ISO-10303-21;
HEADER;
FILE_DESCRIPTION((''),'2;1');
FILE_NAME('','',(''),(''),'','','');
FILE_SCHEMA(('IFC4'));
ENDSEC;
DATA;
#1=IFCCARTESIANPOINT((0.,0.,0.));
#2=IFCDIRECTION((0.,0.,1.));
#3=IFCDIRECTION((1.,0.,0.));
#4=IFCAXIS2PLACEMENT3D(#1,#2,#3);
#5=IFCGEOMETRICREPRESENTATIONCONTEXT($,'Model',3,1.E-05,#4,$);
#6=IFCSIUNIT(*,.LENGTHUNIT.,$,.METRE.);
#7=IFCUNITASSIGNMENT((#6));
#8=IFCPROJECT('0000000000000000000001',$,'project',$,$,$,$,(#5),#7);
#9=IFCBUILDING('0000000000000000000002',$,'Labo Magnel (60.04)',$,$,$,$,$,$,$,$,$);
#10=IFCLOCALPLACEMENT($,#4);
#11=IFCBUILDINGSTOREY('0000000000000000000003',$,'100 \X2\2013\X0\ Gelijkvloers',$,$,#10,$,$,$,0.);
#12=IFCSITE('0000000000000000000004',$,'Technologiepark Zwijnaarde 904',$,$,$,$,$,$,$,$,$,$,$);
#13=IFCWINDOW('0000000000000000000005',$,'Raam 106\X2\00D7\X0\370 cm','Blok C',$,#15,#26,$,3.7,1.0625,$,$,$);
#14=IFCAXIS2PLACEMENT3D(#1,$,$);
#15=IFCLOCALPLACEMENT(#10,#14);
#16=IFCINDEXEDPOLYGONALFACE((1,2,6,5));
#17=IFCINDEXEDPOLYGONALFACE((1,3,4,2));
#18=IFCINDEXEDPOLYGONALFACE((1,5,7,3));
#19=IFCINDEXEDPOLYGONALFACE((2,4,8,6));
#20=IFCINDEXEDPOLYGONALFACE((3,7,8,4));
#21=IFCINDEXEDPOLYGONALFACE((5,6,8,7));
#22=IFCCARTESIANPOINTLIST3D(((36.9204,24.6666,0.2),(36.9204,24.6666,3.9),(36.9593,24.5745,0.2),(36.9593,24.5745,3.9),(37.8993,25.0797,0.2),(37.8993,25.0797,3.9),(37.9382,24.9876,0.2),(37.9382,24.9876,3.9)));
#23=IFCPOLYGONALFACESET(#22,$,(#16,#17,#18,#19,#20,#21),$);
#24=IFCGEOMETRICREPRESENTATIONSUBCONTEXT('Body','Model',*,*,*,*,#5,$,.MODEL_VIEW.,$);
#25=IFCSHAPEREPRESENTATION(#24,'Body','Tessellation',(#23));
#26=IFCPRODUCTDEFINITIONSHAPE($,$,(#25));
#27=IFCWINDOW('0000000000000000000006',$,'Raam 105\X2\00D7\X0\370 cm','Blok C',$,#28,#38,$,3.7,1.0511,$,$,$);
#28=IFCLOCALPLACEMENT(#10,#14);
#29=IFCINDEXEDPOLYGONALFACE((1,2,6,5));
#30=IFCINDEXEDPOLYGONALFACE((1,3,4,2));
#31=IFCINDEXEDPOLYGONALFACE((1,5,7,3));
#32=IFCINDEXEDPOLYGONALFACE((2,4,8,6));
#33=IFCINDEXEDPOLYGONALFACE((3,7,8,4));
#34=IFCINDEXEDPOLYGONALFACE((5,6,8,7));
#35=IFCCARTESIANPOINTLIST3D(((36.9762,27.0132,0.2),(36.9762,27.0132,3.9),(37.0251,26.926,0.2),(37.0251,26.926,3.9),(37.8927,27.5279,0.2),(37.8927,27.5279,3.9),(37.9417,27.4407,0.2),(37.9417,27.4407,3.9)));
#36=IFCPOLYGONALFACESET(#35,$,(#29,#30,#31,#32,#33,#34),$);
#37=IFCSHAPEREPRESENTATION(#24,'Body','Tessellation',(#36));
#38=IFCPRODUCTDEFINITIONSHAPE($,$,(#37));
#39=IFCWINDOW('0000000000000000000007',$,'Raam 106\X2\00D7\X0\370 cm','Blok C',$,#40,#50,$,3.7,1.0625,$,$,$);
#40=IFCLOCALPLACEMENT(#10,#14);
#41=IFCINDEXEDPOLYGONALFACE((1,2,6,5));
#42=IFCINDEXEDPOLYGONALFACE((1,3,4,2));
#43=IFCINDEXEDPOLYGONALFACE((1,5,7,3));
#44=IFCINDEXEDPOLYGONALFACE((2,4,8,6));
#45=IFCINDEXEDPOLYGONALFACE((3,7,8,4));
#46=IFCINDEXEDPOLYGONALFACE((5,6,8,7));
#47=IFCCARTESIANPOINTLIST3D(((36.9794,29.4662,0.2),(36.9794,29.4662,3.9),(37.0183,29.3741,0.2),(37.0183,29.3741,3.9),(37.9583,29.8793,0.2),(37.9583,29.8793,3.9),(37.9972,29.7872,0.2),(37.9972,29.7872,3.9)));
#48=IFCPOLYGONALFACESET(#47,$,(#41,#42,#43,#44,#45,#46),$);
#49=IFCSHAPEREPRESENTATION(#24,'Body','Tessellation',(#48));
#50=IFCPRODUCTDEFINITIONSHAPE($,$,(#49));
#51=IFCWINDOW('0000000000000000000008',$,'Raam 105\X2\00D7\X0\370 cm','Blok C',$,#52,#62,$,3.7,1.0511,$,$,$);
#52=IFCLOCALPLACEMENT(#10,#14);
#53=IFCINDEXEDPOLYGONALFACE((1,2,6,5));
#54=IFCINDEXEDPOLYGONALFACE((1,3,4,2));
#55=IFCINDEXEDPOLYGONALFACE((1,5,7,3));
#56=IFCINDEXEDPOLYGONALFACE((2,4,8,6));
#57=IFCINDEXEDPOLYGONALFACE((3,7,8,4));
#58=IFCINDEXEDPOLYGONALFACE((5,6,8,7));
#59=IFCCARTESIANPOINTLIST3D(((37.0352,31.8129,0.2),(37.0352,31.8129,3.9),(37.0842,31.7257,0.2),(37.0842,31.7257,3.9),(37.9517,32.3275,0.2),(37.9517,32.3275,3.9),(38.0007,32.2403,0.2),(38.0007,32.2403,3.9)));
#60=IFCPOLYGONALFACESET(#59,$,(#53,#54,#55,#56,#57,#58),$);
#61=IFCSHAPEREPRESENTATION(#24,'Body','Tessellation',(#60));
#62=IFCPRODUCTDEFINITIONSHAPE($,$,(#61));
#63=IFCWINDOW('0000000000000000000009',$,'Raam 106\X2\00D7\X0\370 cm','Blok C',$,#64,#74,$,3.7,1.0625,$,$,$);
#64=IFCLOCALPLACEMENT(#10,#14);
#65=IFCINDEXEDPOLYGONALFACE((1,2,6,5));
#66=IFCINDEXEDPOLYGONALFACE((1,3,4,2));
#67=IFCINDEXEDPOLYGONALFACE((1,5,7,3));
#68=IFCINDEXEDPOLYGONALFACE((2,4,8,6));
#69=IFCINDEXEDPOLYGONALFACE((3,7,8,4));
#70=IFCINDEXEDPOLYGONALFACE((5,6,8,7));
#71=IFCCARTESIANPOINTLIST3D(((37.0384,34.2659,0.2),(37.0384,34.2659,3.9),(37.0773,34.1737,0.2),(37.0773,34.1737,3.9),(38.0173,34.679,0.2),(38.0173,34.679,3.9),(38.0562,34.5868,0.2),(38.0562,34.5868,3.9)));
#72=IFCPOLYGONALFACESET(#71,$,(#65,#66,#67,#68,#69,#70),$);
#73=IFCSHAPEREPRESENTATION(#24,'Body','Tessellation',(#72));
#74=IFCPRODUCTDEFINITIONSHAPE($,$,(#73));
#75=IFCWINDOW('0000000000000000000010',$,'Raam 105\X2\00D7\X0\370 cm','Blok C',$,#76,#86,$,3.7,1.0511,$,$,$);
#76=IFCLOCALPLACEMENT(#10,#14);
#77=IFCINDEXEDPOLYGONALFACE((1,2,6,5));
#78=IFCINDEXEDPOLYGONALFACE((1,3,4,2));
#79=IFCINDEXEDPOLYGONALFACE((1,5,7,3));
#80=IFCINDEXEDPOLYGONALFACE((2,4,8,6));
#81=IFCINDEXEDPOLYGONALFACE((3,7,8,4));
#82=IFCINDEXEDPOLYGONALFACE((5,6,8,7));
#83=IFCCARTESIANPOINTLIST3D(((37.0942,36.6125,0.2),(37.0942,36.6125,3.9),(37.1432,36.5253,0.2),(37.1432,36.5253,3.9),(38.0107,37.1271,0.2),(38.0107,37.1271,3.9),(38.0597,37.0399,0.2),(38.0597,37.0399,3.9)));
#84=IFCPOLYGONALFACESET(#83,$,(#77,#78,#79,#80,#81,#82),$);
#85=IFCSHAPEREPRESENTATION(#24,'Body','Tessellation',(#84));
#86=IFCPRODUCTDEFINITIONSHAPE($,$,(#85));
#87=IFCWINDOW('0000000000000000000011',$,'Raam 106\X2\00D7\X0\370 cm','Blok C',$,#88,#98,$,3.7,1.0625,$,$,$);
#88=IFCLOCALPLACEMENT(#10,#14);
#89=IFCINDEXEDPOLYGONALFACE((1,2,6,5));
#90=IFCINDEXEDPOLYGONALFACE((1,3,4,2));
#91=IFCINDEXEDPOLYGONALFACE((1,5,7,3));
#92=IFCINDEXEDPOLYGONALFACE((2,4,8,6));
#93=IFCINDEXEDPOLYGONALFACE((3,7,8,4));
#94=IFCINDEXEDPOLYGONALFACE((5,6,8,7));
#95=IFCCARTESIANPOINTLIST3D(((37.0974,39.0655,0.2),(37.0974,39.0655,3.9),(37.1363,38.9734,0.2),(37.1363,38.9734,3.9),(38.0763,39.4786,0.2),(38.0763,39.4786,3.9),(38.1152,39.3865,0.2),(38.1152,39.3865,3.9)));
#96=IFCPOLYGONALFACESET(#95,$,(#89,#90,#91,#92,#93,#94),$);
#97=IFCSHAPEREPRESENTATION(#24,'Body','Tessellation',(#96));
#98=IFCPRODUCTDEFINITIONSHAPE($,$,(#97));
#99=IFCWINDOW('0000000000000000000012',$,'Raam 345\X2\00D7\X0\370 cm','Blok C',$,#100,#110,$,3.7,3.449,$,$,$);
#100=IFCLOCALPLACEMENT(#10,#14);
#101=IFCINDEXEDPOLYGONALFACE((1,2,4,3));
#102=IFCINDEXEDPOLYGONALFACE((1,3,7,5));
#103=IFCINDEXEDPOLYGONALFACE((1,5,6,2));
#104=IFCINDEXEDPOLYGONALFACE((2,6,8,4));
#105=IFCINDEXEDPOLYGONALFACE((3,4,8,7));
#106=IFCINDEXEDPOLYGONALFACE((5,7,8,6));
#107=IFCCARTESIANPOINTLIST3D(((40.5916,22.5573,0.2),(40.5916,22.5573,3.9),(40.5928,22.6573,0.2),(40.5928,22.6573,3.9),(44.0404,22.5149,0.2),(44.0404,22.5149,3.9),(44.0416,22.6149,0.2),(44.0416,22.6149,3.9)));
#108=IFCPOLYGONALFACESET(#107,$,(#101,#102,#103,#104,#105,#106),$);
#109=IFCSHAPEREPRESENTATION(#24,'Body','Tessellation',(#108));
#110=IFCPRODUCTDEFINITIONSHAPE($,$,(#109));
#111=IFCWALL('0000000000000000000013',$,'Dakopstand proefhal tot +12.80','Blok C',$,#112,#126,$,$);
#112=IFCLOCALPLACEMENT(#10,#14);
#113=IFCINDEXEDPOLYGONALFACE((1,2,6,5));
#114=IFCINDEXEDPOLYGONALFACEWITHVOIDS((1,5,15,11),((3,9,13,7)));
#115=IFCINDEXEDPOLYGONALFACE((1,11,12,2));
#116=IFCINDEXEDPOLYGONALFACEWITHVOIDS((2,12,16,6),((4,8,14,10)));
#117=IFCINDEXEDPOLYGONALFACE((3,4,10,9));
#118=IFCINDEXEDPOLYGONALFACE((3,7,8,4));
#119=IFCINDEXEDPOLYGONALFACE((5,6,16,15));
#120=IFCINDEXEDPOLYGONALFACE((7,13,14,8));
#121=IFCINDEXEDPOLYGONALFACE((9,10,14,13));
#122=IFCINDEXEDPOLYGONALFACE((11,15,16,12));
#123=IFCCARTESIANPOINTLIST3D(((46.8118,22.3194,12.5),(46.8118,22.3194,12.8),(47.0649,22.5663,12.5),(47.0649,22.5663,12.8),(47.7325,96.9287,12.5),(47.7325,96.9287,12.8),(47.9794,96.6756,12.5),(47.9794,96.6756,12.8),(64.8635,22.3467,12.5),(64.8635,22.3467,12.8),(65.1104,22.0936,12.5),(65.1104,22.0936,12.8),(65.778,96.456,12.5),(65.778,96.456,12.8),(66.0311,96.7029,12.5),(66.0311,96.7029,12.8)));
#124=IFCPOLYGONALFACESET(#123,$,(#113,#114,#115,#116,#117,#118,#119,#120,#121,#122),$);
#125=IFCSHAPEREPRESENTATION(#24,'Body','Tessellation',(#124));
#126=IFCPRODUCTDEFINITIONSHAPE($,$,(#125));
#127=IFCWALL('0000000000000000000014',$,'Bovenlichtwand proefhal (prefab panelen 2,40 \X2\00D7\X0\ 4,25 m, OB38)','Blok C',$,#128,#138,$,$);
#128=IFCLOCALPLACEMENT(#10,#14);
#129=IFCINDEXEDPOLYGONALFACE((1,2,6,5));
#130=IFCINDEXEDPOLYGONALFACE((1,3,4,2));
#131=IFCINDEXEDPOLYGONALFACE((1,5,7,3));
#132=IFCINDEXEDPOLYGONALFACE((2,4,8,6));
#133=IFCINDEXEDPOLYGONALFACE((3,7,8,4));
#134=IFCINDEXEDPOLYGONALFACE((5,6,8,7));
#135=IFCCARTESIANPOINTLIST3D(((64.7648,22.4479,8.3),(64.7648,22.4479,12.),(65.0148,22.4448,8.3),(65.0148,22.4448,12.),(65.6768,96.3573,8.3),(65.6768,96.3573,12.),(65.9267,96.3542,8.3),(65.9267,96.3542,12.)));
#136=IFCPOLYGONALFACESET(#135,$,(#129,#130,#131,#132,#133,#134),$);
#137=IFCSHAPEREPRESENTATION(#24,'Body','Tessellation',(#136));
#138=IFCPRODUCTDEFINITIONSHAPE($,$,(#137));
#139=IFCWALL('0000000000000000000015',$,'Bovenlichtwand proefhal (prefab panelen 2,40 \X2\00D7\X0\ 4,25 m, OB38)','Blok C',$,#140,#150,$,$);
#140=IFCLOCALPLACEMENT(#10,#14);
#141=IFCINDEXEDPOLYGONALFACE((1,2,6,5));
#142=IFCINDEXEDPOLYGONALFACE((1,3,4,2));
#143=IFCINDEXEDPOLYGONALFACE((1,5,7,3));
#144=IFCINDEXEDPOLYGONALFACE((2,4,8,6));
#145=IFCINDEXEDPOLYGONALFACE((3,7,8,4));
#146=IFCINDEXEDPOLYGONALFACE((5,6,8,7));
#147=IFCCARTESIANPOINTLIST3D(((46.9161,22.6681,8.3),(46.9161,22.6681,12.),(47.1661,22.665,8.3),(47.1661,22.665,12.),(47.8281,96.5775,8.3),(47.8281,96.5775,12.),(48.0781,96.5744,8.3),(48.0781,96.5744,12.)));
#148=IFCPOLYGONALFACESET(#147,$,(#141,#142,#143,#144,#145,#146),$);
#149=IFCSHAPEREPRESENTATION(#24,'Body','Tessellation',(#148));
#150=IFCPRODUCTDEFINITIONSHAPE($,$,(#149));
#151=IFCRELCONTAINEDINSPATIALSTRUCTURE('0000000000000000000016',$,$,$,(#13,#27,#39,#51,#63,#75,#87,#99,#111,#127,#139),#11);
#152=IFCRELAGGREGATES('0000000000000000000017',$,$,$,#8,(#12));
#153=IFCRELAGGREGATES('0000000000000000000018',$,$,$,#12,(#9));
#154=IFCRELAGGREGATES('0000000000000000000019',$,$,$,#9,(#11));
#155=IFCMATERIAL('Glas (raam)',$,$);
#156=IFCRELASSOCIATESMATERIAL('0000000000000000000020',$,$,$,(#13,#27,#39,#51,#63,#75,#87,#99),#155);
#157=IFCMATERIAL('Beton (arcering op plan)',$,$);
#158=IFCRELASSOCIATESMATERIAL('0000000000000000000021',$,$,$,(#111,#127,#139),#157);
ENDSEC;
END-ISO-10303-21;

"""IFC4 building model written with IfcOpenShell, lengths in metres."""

from ifc_helpers import new_model, si_unit, frame, origin, origin_with_axes, place, context, subcontext, project, spatial, polyline, outline, extrude, material, element, save


model = new_model("IFC4")

# Units and contexts
model_context = context("Model", 3, precision=1e-05, world=origin_with_axes())
body_context = subcontext(model_context, "Body", "Model", "MODEL_VIEW")
ifc_project = project(units=[si_unit("LENGTHUNIT", "METRE")], contexts=[model_context])

# Site, building, storey
site = spatial("IfcSite", under=ifc_project, Name="Technologiepark Zwijnaarde 904")
building = spatial("IfcBuilding", under=site, Name="Labo Magnel (60.04)")
storey_placement = place(None, origin_with_axes())
storey = spatial("IfcBuildingStorey", under=building, at=storey_placement, Name="100 – Gelijkvloers", Elevation=0.0)

# Shared definitions
ifc_material_1 = material(Name="Beton (arcering op plan)")

# Windows
ifc_material_2 = material(Name="Glas (raam)")
window_1_placement = place(storey_placement, frame((36.9399, 24.6205, 0.2), z_axis=(0.0, 0.0, 1.0), x_axis=(0.921323, 0.388799, 0.0)))
element("IfcWindow", 1, at=window_1_placement, inside=storey, material=ifc_material_2, Name="Raam 106×370 cm", Description="Blok C", OverallHeight=3.7, OverallWidth=1.0625, context=body_context, shape_type="SweptSolid", body=[
    extrude(outline(polyline([(0.0, -0.05), (1.0625, -0.05), (1.0625, 0.05), (0.0, 0.05), (0.0, -0.05)])), origin(), (0.0, 0.0, 1.0), 3.7),
])
window_2_placement = place(storey_placement, frame((37.9172, 27.4843, 0.2), z_axis=(0.0, 0.0, 1.0), x_axis=(-0.87195, -0.489595, 0.0)))
element("IfcWindow", 2, at=window_2_placement, inside=storey, material=ifc_material_2, Name="Raam 105×370 cm", Description="Blok C", OverallHeight=3.7, OverallWidth=1.0511, context=body_context, shape_type="SweptSolid", body=[
    extrude(outline(polyline([(0.0, -0.05), (1.0511, -0.05), (1.0511, 0.05), (0.0, 0.05), (0.0, -0.05)])), origin(), (0.0, 0.0, 1.0), 3.7),
])
window_3_placement = place(storey_placement, frame((36.9989, 29.4202, 0.2), z_axis=(0.0, 0.0, 1.0), x_axis=(0.921323, 0.388799, 0.0)))
element("IfcWindow", 3, at=window_3_placement, inside=storey, material=ifc_material_2, Name="Raam 106×370 cm", Description="Blok C", OverallHeight=3.7, OverallWidth=1.0625, context=body_context, shape_type="SweptSolid", body=[
    extrude(outline(polyline([(0.0, -0.05), (1.0625, -0.05), (1.0625, 0.05), (0.0, 0.05), (0.0, -0.05)])), origin(), (0.0, 0.0, 1.0), 3.7),
])
window_4_placement = place(storey_placement, frame((37.9762, 32.2839, 0.2), z_axis=(0.0, 0.0, 1.0), x_axis=(-0.87195, -0.489595, 0.0)))
element("IfcWindow", 4, at=window_4_placement, inside=storey, material=ifc_material_2, Name="Raam 105×370 cm", Description="Blok C", OverallHeight=3.7, OverallWidth=1.0511, context=body_context, shape_type="SweptSolid", body=[
    extrude(outline(polyline([(0.0, -0.05), (1.0511, -0.05), (1.0511, 0.05), (0.0, 0.05), (0.0, -0.05)])), origin(), (0.0, 0.0, 1.0), 3.7),
])
window_5_placement = place(storey_placement, frame((37.0579, 34.2198, 0.2), z_axis=(0.0, 0.0, 1.0), x_axis=(0.921323, 0.388799, 0.0)))
element("IfcWindow", 5, at=window_5_placement, inside=storey, material=ifc_material_2, Name="Raam 106×370 cm", Description="Blok C", OverallHeight=3.7, OverallWidth=1.0625, context=body_context, shape_type="SweptSolid", body=[
    extrude(outline(polyline([(0.0, -0.05), (1.0625, -0.05), (1.0625, 0.05), (0.0, 0.05), (0.0, -0.05)])), origin(), (0.0, 0.0, 1.0), 3.7),
])
window_6_placement = place(storey_placement, frame((38.0352, 37.0835, 0.2), z_axis=(0.0, 0.0, 1.0), x_axis=(-0.87195, -0.489595, 0.0)))
element("IfcWindow", 6, at=window_6_placement, inside=storey, material=ifc_material_2, Name="Raam 105×370 cm", Description="Blok C", OverallHeight=3.7, OverallWidth=1.0511, context=body_context, shape_type="SweptSolid", body=[
    extrude(outline(polyline([(0.0, -0.05), (1.0511, -0.05), (1.0511, 0.05), (0.0, 0.05), (0.0, -0.05)])), origin(), (0.0, 0.0, 1.0), 3.7),
])
window_7_placement = place(storey_placement, frame((37.1169, 39.0194, 0.2), z_axis=(0.0, 0.0, 1.0), x_axis=(0.921323, 0.388799, 0.0)))
element("IfcWindow", 7, at=window_7_placement, inside=storey, material=ifc_material_2, Name="Raam 106×370 cm", Description="Blok C", OverallHeight=3.7, OverallWidth=1.0625, context=body_context, shape_type="SweptSolid", body=[
    extrude(outline(polyline([(0.0, -0.05), (1.0625, -0.05), (1.0625, 0.05), (0.0, 0.05), (0.0, -0.05)])), origin(), (0.0, 0.0, 1.0), 3.7),
])
window_8_placement = place(storey_placement, frame((44.041, 22.5649, 0.2), z_axis=(0.0, 0.0, 1.0), x_axis=(-0.999924, 0.012293, 0.0)))
element("IfcWindow", 8, at=window_8_placement, inside=storey, material=ifc_material_2, Name="Raam 345×370 cm", Description="Blok C", OverallHeight=3.7, OverallWidth=3.449, context=body_context, shape_type="SweptSolid", body=[
    extrude(outline(polyline([(0.0, -0.05), (3.449, -0.05), (3.449, 0.05), (0.0, 0.05), (0.0, -0.05)])), origin(), (0.0, 0.0, 1.0), 3.7),
])

# Walls
wall_1_placement = place(storey_placement, frame((0.0, 0.0, 12.5), z_axis=(0.0, 0.0, 1.0), x_axis=(1.0, 0.0, 0.0)))
element("IfcWall", 9, at=wall_1_placement, inside=storey, material=ifc_material_1, Name="Dakopstand proefhal tot +12.80", Description="Blok C", context=body_context, shape_type="SweptSolid", body=[
    extrude(outline(polyline([(65.1104, 22.0936), (46.8118, 22.3194), (47.7325, 96.9287), (66.0311, 96.7029), (65.1104, 22.0936)]), holes=[polyline([(47.9794, 96.6756), (47.0649, 22.5663), (64.8635, 22.3467), (65.778, 96.456), (47.9794, 96.6756)])]), origin(), (0.0, 0.0, 1.0), 0.3),
])
wall_2_placement = place(storey_placement, frame((0.0, 0.0, 8.3), z_axis=(0.0, 0.0, 1.0), x_axis=(1.0, 0.0, 0.0)))
element("IfcWall", 10, at=wall_2_placement, inside=storey, material=ifc_material_1, Name="Bovenlichtwand proefhal (prefab panelen 2,40 × 4,25 m, OB38)", Description="Blok C", context=body_context, shape_type="SweptSolid", body=[
    extrude(outline(polyline([(65.6768, 96.3573), (64.7648, 22.4479), (65.0148, 22.4448), (65.9267, 96.3542), (65.6768, 96.3573)])), origin(), (0.0, 0.0, 1.0), 3.7),
])
wall_3_placement = place(storey_placement, frame((0.0, 0.0, 8.3), z_axis=(0.0, 0.0, 1.0), x_axis=(1.0, 0.0, 0.0)))
element("IfcWall", 11, at=wall_3_placement, inside=storey, material=ifc_material_1, Name="Bovenlichtwand proefhal (prefab panelen 2,40 × 4,25 m, OB38)", Description="Blok C", context=body_context, shape_type="SweptSolid", body=[
    extrude(outline(polyline([(48.0781, 96.5744), (47.1661, 22.665), (46.9161, 22.6681), (47.8281, 96.5775), (48.0781, 96.5744)])), origin(), (0.0, 0.0, 1.0), 3.7),
])

save(model, "model.ifc")
